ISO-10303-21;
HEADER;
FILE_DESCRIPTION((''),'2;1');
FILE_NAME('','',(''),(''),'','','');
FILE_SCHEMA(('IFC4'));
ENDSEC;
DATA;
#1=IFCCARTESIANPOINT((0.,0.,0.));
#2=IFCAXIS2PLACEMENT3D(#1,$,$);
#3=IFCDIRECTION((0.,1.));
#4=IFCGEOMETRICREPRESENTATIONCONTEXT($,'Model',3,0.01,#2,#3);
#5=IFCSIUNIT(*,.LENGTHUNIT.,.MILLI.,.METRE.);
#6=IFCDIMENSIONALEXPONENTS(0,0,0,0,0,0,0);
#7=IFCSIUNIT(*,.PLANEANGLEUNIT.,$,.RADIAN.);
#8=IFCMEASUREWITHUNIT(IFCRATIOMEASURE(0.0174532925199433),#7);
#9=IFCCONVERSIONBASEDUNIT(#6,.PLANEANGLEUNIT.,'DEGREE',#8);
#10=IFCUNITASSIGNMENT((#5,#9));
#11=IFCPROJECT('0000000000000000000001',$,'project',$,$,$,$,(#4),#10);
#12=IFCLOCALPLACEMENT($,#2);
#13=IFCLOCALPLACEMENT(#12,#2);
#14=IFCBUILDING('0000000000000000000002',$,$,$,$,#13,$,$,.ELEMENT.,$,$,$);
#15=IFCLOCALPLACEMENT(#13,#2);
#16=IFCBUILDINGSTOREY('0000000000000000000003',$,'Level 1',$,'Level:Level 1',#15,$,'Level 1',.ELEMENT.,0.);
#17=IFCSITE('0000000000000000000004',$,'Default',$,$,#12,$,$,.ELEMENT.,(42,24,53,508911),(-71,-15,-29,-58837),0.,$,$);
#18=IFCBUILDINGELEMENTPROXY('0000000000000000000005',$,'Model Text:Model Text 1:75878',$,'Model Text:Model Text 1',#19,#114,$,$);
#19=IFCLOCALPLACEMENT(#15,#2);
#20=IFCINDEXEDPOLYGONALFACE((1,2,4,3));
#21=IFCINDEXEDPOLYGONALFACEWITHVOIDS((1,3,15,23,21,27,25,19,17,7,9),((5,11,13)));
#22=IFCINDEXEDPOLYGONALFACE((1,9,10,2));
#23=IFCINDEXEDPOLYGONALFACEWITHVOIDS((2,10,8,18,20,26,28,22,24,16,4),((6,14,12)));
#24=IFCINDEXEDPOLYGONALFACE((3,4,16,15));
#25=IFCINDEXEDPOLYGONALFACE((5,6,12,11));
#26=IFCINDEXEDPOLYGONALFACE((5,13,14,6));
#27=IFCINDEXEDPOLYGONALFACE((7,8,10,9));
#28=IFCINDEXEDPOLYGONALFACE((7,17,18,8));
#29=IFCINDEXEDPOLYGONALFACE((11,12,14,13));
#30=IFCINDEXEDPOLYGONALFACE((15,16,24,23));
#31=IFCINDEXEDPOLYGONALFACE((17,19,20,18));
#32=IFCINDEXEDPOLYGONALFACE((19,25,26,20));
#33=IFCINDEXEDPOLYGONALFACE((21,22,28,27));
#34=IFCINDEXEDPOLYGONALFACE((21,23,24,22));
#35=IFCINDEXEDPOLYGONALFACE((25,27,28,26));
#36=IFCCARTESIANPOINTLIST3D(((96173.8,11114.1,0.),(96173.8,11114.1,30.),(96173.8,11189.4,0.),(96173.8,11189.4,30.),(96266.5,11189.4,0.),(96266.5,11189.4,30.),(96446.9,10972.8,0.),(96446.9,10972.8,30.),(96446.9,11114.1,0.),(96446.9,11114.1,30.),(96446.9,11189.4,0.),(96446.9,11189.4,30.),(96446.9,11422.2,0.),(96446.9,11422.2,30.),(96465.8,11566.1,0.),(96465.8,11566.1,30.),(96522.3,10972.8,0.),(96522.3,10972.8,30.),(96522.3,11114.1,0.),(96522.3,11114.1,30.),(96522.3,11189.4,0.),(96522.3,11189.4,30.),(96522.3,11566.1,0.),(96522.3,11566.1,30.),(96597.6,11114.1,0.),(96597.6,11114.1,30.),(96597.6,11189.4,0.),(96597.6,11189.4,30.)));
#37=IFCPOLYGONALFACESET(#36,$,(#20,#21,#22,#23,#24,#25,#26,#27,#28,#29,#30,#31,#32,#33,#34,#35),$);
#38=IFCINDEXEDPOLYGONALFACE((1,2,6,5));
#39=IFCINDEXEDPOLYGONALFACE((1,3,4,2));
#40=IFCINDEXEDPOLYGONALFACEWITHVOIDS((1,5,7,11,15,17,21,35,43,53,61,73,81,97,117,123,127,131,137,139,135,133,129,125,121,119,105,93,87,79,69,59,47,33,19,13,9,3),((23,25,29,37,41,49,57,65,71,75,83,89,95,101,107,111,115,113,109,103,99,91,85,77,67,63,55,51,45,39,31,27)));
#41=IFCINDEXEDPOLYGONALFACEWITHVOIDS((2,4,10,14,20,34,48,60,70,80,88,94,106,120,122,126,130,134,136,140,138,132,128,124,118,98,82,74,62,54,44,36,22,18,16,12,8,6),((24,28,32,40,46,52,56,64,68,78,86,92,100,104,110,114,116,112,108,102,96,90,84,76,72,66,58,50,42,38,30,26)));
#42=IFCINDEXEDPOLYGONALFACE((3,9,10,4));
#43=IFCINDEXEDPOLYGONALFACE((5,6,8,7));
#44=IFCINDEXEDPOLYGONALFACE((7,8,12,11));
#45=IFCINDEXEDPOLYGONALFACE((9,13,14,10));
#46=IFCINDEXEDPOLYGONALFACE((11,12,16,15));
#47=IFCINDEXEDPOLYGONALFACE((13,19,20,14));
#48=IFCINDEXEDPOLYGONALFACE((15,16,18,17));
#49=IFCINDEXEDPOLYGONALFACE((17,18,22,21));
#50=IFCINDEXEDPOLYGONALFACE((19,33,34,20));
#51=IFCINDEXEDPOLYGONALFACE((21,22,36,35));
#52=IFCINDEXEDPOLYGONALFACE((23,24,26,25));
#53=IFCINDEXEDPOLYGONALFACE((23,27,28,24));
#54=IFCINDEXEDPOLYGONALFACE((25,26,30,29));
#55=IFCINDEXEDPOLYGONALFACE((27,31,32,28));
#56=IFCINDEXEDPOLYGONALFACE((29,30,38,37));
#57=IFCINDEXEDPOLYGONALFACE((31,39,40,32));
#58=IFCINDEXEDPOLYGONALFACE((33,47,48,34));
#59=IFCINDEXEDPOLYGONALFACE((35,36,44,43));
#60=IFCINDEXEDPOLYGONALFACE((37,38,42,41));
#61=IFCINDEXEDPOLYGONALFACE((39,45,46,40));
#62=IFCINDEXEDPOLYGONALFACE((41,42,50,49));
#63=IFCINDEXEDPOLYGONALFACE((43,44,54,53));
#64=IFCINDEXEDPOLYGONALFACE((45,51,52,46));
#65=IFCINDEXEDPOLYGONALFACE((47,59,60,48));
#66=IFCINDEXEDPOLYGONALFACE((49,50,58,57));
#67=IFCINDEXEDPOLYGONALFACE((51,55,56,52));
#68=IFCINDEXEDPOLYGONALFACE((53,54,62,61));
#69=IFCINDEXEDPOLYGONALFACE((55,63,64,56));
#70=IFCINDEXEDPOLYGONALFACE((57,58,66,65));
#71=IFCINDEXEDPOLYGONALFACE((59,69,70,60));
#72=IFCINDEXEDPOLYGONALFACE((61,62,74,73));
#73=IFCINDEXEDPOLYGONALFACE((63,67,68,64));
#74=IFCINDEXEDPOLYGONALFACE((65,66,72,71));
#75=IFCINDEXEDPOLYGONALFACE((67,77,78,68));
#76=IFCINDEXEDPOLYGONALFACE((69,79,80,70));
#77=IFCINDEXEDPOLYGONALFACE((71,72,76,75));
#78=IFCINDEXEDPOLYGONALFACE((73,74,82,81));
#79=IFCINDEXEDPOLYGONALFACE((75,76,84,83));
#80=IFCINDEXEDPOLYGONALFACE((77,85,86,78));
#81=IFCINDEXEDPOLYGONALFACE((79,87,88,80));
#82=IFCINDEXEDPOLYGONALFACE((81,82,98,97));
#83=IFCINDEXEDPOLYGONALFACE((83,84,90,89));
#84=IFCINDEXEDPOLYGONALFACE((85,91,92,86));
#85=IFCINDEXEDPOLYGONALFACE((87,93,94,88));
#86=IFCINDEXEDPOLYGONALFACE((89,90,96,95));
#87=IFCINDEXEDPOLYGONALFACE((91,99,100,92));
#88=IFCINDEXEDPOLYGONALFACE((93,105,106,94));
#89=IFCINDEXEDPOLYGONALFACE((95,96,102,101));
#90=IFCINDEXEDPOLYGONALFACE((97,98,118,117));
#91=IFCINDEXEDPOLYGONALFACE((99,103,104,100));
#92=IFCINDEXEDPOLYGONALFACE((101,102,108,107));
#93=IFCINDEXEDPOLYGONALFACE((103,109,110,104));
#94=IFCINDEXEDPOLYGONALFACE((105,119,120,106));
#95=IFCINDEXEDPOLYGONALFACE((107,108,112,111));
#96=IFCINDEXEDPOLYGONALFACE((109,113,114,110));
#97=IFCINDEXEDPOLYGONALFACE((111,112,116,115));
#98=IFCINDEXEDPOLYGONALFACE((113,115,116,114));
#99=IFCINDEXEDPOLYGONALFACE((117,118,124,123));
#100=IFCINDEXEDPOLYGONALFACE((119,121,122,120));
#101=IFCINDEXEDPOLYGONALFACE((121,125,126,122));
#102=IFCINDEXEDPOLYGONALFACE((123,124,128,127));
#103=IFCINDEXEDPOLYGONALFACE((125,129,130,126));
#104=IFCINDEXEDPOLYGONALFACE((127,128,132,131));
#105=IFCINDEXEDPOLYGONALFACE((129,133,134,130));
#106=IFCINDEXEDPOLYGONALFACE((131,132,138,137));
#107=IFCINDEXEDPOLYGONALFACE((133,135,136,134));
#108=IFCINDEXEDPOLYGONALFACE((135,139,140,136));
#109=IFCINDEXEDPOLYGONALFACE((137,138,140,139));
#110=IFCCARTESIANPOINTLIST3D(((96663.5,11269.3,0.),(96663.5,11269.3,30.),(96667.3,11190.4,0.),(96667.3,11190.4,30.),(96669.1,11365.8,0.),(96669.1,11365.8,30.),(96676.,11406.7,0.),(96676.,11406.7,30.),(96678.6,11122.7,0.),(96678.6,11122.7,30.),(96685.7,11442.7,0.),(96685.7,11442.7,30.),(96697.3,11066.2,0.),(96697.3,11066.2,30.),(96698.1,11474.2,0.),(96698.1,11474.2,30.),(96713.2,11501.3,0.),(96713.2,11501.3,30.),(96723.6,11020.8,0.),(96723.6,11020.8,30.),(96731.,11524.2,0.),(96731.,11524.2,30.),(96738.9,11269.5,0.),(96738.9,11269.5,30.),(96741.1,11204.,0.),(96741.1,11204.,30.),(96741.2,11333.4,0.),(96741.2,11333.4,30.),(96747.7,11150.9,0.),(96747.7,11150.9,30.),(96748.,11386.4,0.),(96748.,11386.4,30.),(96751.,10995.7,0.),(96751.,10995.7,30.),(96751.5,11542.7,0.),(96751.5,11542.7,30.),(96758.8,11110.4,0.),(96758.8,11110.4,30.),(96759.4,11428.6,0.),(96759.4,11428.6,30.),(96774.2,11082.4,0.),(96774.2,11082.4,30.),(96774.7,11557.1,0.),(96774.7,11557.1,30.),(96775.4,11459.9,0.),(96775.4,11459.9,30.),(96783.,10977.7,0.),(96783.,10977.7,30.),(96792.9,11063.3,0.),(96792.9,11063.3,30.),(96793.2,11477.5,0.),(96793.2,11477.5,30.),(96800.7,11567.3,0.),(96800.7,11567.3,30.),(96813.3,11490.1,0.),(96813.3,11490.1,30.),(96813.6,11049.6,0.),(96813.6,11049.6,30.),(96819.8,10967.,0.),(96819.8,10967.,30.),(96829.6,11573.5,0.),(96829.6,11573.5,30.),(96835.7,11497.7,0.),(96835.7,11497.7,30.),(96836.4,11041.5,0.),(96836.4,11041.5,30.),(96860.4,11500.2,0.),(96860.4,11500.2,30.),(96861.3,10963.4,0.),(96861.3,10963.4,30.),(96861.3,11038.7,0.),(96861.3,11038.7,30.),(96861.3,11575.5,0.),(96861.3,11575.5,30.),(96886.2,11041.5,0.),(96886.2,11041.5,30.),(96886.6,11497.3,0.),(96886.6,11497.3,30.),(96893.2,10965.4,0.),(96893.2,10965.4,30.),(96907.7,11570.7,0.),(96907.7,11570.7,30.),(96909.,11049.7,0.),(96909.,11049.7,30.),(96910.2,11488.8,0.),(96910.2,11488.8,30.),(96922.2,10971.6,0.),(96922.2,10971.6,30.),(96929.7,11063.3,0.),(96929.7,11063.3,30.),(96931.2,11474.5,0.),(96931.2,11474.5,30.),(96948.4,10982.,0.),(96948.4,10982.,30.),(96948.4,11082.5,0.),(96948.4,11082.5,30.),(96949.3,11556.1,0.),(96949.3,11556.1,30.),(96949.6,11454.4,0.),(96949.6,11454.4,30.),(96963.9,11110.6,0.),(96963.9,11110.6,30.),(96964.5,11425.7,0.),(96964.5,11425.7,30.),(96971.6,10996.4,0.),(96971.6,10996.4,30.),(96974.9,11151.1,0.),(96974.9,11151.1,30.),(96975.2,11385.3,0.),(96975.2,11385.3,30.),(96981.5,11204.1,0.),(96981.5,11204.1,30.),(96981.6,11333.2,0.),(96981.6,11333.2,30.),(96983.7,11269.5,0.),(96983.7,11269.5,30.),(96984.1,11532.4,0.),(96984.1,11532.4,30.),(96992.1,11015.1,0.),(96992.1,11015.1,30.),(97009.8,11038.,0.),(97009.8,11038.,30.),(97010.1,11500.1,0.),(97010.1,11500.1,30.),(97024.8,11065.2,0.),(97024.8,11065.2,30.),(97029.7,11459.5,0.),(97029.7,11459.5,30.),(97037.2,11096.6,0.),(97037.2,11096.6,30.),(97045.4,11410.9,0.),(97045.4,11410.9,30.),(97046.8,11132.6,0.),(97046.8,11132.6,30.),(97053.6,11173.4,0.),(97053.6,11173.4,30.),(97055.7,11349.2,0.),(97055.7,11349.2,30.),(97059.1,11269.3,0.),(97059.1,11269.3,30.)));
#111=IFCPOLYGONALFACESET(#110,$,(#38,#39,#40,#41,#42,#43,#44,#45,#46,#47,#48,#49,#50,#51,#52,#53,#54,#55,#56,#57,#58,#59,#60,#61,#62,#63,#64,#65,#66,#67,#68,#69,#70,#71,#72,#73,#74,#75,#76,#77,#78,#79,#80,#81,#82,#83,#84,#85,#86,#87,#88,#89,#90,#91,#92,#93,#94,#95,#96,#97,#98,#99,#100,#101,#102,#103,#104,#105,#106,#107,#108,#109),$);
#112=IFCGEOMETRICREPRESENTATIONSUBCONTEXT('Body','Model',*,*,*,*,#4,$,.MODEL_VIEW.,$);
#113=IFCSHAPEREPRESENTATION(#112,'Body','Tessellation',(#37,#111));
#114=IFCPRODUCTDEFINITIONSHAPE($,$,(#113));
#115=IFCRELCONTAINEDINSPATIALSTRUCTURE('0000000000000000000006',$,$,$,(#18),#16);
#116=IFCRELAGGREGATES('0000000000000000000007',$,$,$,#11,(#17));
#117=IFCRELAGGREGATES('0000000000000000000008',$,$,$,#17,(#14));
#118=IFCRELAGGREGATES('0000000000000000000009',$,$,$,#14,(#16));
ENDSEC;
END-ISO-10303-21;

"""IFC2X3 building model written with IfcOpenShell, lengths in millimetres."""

from ifc_helpers import new_model, entity, si_unit, converted_unit, direction, frame, origin, place, context, subcontext, project, spatial, polyline, outline, extrude, element, save


model = new_model("IFC2X3")

# Units and contexts
model_context = context("Model", 3, precision=0.01, world=origin(), true_north=direction((0.0, 1.0)))
body_context = subcontext(model_context, "Body", "Model", "MODEL_VIEW")
ifc_project = project(units=[si_unit("LENGTHUNIT", "METRE", prefix="MILLI"), converted_unit("PLANEANGLEUNIT", "DEGREE", entity("IfcRatioMeasure", 0.0174532925199433), si_unit("PLANEANGLEUNIT", "RADIAN"), dimensions=[0, 0, 0, 0, 0, 0, 0])], contexts=[model_context])

# Site, building, storey
site_placement = place(None, origin())
site = spatial("IfcSite", under=ifc_project, at=site_placement, Name="Default", CompositionType="ELEMENT", RefLatitude=(42, 24, 53, 508911), RefLongitude=(-71, -15, -29, -58837), RefElevation=0.0)
building_placement = place(site_placement, origin())
building = spatial("IfcBuilding", under=site, at=building_placement, CompositionType="ELEMENT")
storey_placement = place(building_placement, origin())
storey = spatial("IfcBuildingStorey", under=building, at=storey_placement, Name="Level 1", ObjectType="Level:Level 1", LongName="Level 1", CompositionType="ELEMENT", Elevation=0.0)

# Building element proxy
proxy_1_placement = place(storey_placement, origin())
element("IfcBuildingElementProxy", 1, at=proxy_1_placement, inside=storey, Name="Model Text:Model Text 1:75878", ObjectType="Model Text:Model Text 1", context=body_context, shape_type="SweptSolid", body=[
    extrude(outline(polyline([(-6.8, -218.3), (68.5, -218.3), (68.5, -77.1), (143.8, -77.1), (143.8, -1.7), (68.5, -1.7), (68.5, 375.0), (12.0, 375.0), (-280.0, -1.7), (-280.0, -77.1), (-6.8, -77.1), (-6.8, -218.3)]), holes=[polyline([(-6.8, -1.7), (-187.3, -1.7), (-6.8, 231.1), (-6.8, -1.7)])]), frame((96453.8, 11191.1, 0.0)), (0.0, 0.0, 1.0), 30.0),
    extrude(outline(polyline([(-10.6, -198.7), (68.3, -198.7), (136.5, -190.7), (193.9, -174.7), (240.5, -150.6), (266.9, -124.4), (286.3, -93.2), (298.8, -57.0), (304.3, -15.7), (303.8, 16.2), (299.0, 45.5), (289.9, 72.1), (276.6, 96.0), (258.9, 117.3), (236.9, 136.2), (210.4, 152.5), (179.6, 166.3), (144.1, 177.6), (103.7, 186.3), (8.2, 196.4), (-71.8, 196.7), (-134.0, 189.4), (-183.3, 176.1), (-224.7, 158.4), (-258.2, 133.9), (-283.5, 100.3), (-300.1, 59.5), (-307.1, 13.4), (-306.6, -18.4), (-301.8, -47.5), (-292.8, -74.0), (-279.6, -97.9), (-262.0, -119.2), (-240.0, -138.1), (-213.6, -154.5), (-182.8, -168.4), (-147.3, -179.8), (-106.7, -188.6), (-10.6, -198.7)]), holes=[polyline([(-7.2, -123.5), (-71.0, -118.2), (-123.6, -108.8), (-165.2, -95.4), (-195.7, -78.0), (-212.4, -59.4), (-224.1, -38.7), (-230.6, -15.9), (-231.9, 8.9), (-227.8, 35.0), (-218.1, 58.1), (-202.8, 78.4), (-182.0, 95.8), (-152.6, 109.4), (-111.7, 118.1), (-59.4, 122.0), (4.4, 121.1), (69.6, 115.8), (122.2, 106.7), (162.2, 93.7), (189.5, 77.0), (207.7, 57.4), (220.4, 36.0), (227.5, 12.8), (229.1, -12.1), (225.2, -36.8), (215.9, -59.2), (201.3, -79.3), (181.4, -97.1), (152.6, -111.2), (111.6, -120.3), (58.3, -124.4), (-7.2, -123.5)])]), frame((96862.6, 11268.1, 0.0), z_axis=(0.0, 0.0, 1.0), x_axis=(0.047515, -0.998871, 0.0)), (0.0, 0.0, 1.0), 30.0),
])

save(model, "model.ifc")
